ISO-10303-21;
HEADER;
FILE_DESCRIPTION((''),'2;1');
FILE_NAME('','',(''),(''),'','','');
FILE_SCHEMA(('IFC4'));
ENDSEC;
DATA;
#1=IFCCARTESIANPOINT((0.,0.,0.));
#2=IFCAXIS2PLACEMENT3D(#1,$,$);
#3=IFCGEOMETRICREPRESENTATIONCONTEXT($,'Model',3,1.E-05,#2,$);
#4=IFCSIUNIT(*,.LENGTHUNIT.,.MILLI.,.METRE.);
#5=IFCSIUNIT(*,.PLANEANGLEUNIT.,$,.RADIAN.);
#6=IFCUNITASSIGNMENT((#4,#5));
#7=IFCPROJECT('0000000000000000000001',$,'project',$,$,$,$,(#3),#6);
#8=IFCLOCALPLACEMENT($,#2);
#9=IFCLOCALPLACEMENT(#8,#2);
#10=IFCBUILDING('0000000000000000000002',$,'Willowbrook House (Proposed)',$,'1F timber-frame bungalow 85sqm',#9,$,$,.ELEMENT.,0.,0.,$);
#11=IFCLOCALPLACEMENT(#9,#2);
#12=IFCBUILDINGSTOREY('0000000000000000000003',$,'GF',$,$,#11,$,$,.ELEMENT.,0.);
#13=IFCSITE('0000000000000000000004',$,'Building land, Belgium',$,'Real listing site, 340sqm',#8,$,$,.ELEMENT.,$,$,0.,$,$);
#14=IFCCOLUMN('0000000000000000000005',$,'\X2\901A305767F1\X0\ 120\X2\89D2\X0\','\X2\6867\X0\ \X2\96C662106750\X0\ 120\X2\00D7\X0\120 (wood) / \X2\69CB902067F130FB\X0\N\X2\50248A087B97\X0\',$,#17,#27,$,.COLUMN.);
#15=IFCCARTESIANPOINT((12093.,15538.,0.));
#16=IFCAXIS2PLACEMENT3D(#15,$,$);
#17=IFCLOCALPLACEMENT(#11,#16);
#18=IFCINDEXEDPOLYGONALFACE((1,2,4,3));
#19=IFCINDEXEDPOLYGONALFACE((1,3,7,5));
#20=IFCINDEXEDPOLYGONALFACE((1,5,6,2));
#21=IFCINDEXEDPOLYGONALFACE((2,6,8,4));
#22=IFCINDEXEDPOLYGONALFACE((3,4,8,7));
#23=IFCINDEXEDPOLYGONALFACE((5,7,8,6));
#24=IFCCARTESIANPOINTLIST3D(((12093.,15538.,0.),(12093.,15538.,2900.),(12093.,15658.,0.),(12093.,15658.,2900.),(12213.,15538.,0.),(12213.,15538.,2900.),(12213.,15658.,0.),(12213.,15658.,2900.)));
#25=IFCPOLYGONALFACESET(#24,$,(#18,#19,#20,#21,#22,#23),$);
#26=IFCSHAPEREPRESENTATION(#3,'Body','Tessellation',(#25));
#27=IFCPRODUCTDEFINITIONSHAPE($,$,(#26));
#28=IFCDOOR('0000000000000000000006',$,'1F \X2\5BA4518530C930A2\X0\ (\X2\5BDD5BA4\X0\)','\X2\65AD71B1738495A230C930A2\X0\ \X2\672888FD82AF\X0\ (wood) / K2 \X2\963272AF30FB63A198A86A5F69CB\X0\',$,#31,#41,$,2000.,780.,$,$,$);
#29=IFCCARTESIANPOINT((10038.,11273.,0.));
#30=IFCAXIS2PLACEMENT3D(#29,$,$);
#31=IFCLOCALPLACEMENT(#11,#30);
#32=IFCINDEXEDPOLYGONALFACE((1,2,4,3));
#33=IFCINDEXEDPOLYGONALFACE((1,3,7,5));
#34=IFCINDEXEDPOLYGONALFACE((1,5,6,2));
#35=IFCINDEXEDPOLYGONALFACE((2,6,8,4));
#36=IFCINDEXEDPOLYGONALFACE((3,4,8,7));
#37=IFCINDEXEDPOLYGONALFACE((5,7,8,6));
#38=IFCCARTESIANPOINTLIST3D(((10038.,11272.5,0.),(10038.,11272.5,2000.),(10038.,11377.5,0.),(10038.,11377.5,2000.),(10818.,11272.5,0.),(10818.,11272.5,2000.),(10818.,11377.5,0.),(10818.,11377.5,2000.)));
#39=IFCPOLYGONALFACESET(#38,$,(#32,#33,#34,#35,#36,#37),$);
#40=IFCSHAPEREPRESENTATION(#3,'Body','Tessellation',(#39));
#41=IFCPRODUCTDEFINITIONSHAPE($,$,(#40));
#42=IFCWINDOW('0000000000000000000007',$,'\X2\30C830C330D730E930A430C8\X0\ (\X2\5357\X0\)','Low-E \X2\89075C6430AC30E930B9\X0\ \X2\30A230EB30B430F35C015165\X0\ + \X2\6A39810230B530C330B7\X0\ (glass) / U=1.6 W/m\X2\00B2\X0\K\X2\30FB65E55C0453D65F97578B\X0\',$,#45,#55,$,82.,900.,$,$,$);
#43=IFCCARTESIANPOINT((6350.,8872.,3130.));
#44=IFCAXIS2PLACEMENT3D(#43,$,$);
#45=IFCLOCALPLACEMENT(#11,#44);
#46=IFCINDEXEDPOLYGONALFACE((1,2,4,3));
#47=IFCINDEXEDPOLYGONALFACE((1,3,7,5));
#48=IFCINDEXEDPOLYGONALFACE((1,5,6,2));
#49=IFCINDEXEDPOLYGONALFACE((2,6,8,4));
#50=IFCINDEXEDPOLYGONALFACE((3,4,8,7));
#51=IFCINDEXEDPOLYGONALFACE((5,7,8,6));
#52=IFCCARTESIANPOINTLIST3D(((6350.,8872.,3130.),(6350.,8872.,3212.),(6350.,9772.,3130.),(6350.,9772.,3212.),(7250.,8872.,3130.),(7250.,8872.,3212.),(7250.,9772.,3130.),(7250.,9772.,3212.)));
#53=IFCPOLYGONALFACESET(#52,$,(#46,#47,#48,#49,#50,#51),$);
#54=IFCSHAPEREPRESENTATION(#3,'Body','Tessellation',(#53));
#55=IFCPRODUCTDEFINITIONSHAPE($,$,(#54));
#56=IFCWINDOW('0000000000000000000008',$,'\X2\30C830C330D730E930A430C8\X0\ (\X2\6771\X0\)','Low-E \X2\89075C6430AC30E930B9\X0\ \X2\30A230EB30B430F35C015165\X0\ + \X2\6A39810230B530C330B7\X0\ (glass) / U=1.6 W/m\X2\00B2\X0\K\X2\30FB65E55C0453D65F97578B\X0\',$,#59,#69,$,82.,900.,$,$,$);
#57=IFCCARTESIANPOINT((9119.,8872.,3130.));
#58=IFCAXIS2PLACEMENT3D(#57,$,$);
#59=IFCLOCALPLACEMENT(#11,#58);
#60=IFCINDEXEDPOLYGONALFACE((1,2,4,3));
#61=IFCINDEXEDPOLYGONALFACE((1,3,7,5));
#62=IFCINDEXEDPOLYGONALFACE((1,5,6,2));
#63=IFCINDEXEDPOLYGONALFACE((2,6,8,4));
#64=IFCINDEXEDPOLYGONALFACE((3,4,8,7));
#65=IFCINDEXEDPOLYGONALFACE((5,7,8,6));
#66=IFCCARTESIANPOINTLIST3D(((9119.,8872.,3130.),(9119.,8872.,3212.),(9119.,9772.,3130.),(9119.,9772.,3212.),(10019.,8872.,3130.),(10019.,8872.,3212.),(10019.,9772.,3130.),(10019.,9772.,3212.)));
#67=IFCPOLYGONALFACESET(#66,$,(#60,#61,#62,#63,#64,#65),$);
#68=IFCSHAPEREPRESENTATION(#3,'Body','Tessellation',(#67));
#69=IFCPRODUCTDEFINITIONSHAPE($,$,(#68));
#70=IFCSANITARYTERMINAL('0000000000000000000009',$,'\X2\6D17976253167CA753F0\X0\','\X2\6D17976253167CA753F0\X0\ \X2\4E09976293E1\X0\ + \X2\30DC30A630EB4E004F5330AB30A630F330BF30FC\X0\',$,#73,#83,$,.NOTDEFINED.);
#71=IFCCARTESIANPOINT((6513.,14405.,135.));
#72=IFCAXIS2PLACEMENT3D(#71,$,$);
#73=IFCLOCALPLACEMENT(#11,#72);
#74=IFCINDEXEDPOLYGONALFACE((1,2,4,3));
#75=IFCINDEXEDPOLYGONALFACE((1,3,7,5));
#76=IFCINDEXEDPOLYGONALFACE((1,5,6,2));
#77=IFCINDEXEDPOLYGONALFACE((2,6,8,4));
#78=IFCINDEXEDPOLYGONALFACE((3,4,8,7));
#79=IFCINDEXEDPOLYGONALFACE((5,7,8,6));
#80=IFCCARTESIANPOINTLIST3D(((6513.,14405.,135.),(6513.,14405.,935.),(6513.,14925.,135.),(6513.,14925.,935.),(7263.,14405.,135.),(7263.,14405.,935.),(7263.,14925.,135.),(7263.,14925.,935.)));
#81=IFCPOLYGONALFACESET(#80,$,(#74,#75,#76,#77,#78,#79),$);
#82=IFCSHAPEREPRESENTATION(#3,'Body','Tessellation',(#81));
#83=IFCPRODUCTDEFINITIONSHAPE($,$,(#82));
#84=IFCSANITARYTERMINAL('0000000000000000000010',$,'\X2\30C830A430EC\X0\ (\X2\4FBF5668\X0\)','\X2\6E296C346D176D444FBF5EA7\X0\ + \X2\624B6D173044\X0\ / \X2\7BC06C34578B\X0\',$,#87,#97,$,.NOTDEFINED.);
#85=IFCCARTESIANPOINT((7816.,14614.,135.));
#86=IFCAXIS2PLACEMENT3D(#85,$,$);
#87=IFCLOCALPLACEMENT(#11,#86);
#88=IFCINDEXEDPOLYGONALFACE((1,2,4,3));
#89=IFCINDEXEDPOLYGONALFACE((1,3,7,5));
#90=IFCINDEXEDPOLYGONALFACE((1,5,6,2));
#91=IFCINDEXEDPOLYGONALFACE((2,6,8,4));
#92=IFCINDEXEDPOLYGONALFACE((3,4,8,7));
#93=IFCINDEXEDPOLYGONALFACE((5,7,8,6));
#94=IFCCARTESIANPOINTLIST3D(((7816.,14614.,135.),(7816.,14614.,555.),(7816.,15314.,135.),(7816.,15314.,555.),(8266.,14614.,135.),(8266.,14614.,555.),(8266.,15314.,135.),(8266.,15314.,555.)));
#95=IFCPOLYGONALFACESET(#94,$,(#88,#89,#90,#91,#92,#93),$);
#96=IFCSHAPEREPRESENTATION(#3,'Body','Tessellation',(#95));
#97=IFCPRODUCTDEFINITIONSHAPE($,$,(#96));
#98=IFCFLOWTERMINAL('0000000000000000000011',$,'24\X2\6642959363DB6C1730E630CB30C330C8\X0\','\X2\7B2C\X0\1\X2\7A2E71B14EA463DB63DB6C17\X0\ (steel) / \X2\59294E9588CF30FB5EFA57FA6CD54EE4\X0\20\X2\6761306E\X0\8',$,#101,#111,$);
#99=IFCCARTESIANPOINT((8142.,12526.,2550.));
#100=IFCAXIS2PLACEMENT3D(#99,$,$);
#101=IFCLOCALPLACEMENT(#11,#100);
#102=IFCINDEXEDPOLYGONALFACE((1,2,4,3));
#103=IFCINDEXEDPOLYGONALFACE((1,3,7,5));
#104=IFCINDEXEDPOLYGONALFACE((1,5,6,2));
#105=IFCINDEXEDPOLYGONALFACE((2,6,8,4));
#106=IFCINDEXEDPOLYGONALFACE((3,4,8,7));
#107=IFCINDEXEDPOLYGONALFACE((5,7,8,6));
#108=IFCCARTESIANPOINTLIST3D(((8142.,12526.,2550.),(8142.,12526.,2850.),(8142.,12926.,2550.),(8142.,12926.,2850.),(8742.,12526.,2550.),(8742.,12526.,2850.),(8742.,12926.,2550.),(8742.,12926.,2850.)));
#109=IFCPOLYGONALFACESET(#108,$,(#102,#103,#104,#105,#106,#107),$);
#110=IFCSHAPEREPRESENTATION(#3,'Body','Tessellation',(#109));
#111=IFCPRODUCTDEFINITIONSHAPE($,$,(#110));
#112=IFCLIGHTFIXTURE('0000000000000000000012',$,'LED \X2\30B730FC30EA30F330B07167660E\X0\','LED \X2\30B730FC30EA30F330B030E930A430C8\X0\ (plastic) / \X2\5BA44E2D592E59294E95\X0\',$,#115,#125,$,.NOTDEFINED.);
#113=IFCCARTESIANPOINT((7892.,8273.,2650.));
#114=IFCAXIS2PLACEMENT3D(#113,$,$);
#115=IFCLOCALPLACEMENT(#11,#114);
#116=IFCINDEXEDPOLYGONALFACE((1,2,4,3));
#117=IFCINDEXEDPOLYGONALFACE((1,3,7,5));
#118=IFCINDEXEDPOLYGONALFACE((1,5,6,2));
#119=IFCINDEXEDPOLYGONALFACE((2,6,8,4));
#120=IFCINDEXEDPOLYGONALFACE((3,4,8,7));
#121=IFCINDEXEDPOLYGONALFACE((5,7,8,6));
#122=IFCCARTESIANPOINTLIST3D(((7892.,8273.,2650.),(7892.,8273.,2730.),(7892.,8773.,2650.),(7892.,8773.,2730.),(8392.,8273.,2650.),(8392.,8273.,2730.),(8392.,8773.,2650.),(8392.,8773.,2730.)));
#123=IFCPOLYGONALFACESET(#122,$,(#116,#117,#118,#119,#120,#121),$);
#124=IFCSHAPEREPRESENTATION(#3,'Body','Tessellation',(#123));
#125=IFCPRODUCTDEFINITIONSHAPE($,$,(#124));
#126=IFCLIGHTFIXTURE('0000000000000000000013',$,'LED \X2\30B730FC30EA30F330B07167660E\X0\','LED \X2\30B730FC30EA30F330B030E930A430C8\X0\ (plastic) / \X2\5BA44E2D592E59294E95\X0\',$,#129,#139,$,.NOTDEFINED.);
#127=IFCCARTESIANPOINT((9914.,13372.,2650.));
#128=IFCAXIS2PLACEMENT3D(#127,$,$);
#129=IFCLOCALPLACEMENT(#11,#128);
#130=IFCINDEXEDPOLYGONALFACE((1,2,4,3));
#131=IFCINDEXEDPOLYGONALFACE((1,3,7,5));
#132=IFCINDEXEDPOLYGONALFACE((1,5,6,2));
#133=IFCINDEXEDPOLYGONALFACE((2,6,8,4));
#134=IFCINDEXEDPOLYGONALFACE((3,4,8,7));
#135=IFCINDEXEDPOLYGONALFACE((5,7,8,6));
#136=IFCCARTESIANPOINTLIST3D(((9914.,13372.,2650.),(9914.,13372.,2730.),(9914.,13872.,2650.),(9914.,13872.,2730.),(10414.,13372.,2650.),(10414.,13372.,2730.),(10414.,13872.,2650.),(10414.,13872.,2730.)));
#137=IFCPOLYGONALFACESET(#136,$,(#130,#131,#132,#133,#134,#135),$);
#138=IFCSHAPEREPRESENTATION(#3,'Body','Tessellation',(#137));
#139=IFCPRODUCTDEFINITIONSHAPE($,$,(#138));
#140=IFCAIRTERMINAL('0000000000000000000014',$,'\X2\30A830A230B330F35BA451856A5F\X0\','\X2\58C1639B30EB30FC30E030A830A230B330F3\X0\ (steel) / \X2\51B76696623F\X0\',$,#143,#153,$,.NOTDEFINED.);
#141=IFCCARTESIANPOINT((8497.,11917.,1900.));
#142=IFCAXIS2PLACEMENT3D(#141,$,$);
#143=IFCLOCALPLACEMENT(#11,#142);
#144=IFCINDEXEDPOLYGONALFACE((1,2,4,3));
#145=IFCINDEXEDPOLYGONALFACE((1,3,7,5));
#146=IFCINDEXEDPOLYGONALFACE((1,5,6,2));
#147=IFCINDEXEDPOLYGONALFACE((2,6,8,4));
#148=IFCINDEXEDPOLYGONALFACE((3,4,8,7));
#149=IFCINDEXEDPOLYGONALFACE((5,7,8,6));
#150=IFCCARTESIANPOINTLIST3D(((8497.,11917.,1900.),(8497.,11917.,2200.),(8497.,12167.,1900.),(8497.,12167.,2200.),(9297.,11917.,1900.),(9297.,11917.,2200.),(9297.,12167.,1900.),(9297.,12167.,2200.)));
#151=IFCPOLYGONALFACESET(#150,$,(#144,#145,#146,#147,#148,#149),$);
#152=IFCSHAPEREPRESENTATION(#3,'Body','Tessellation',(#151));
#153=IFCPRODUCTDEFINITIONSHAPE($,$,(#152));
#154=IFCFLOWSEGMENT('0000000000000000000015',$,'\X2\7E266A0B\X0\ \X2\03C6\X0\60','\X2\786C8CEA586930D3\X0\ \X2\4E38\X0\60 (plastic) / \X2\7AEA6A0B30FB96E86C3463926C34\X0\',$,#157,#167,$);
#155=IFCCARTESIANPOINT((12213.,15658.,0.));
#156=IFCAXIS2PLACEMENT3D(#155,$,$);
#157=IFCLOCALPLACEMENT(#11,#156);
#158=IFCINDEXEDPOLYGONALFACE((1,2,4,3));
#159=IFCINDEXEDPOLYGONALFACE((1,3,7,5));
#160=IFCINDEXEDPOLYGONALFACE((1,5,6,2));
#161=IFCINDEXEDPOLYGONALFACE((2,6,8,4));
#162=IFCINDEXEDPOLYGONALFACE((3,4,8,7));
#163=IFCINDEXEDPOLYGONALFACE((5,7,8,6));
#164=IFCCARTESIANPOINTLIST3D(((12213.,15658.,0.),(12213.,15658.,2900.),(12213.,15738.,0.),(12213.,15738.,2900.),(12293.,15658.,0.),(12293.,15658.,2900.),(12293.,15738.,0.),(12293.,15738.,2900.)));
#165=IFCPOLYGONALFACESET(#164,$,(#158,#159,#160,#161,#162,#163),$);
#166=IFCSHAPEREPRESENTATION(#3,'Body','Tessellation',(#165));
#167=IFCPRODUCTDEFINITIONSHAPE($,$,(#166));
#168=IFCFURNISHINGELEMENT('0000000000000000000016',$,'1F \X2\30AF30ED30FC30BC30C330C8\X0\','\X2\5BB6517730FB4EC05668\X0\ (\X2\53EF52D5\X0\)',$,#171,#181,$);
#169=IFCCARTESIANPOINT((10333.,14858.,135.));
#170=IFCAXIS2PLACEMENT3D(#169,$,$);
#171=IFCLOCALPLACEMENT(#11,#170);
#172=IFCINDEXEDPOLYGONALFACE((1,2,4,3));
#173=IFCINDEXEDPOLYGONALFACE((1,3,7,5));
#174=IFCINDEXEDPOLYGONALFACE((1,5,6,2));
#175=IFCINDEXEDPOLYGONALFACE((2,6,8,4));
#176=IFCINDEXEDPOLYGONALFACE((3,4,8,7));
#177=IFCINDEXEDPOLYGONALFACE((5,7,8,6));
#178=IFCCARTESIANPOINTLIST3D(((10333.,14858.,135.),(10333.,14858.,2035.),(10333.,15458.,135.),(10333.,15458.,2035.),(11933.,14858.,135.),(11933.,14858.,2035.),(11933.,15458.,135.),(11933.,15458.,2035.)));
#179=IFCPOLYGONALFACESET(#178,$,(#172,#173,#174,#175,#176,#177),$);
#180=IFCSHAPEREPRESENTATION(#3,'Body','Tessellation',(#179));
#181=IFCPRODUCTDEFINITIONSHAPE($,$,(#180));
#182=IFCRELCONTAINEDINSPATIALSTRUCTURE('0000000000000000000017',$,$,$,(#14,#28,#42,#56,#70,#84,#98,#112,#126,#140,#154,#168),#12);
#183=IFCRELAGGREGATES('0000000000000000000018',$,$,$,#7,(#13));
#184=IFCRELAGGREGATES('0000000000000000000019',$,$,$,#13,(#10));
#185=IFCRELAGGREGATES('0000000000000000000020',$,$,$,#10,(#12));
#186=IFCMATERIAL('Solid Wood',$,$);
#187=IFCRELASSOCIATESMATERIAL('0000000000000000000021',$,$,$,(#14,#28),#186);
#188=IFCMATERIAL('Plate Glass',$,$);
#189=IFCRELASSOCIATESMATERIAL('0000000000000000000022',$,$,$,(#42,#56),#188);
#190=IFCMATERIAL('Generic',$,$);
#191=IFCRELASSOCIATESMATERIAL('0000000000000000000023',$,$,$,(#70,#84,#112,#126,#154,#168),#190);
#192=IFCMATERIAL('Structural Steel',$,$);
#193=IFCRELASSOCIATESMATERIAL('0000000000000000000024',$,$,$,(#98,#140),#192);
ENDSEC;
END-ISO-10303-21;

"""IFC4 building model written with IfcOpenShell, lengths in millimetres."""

from ifc_helpers import new_model, si_unit, frame, frame_2d, origin, place, context, project, spatial, rectangle, extrude, material, element, save


model = new_model("IFC4")

# Units and contexts
model_context = context("Model", 3, precision=1e-05, world=origin())
ifc_project = project(units=[si_unit("LENGTHUNIT", "METRE", prefix="MILLI"), si_unit("PLANEANGLEUNIT", "RADIAN")], contexts=[model_context])

# Site, building, storey
site_placement = place(None, origin())
site = spatial("IfcSite", under=ifc_project, at=site_placement, Name="Building land, Belgium", ObjectType="Real listing site, 340sqm", CompositionType="ELEMENT", RefElevation=0.0)
building_placement = place(site_placement, origin())
building = spatial("IfcBuilding", under=site, at=building_placement, Name="Willowbrook House (Proposed)", ObjectType="1F timber-frame bungalow 85sqm", CompositionType="ELEMENT", ElevationOfRefHeight=0.0, ElevationOfTerrain=0.0)
storey_placement = place(building_placement, origin())
storey = spatial("IfcBuildingStorey", under=building, at=storey_placement, Name="GF", CompositionType="ELEMENT", Elevation=0.0)

# Column
ifc_material_1 = material(Name="Solid Wood")
column_1_placement = place(storey_placement, frame((12093.0, 15538.0, 0.0)))
element("IfcColumn", 1, at=column_1_placement, inside=storey, material=ifc_material_1, Name="通し柱 120角", Description="桧 集成材 120×120 (wood) / 構造柱・N値計算", PredefinedType="COLUMN", context=model_context, shape_type="SweptSolid", body=[
    extrude(rectangle(XDim=120.0, YDim=120.0, at=frame_2d((60.0, 60.0))), frame((12093.0, 15538.0, 0.0)), (0.0, 0.0, 1.0), 2900.0),
])

# Door
door_placement = place(storey_placement, frame((10038.0, 11273.0, 0.0)))
element("IfcDoor", 2, at=door_placement, inside=storey, material=ifc_material_1, Name="1F 室内ドア (寝室)", Description="断熱玄関ドア 木製芯 (wood) / K2 防犯・採風機構", OverallHeight=2000.0, OverallWidth=780.0, context=model_context, shape_type="SweptSolid", body=[
    extrude(rectangle(XDim=780.0, YDim=105.0, at=frame_2d((390.0, 52.0))), frame((10038.0, 11273.0, 0.0)), (0.0, 0.0, 1.0), 2000.0),
])

# Windows
ifc_material_2 = material(Name="Plate Glass")
window_1_placement = place(storey_placement, frame((6350.0, 8872.0, 3130.0)))
element("IfcWindow", 3, at=window_1_placement, inside=storey, material=ifc_material_2, Name="トップライト (南)", Description="Low-E 複層ガラス アルゴン封入 + 樹脂サッシ (glass) / U=1.6 W/m²K・日射取得型", OverallHeight=82.0, OverallWidth=900.0, context=model_context, shape_type="SweptSolid", body=[
    extrude(rectangle(XDim=900.0, YDim=900.0, at=frame_2d((450.0, 450.0))), frame((6350.0, 8872.0, 3130.0)), (0.0, 0.0, 1.0), 82.0),
])
window_2_placement = place(storey_placement, frame((9119.0, 8872.0, 3130.0)))
element("IfcWindow", 4, at=window_2_placement, inside=storey, material=ifc_material_2, Name="トップライト (東)", Description="Low-E 複層ガラス アルゴン封入 + 樹脂サッシ (glass) / U=1.6 W/m²K・日射取得型", OverallHeight=82.0, OverallWidth=900.0, context=model_context, shape_type="SweptSolid", body=[
    extrude(rectangle(XDim=900.0, YDim=900.0, at=frame_2d((450.0, 450.0))), frame((9119.0, 8872.0, 3130.0)), (0.0, 0.0, 1.0), 82.0),
])

# Sanitary terminals
ifc_material_3 = material(Name="Generic")
sanitary_terminal_1_placement = place(storey_placement, frame((6513.0, 14405.0, 135.0)))
element("IfcSanitaryTerminal", 5, at=sanitary_terminal_1_placement, inside=storey, material=ifc_material_3, Name="洗面化粧台", Description="洗面化粧台 三面鏡 + ボウル一体カウンター", PredefinedType="NOTDEFINED", context=model_context, shape_type="SweptSolid", body=[
    extrude(rectangle(XDim=750.0, YDim=520.0, at=frame_2d((375.0, 260.0))), frame((6513.0, 14405.0, 135.0)), (0.0, 0.0, 1.0), 800.0),
])
sanitary_terminal_2_placement = place(storey_placement, frame((7816.0, 14614.0, 135.0)))
element("IfcSanitaryTerminal", 6, at=sanitary_terminal_2_placement, inside=storey, material=ifc_material_3, Name="トイレ (便器)", Description="温水洗浄便座 + 手洗い / 節水型", PredefinedType="NOTDEFINED", context=model_context, shape_type="SweptSolid", body=[
    extrude(rectangle(XDim=450.0, YDim=700.0, at=frame_2d((225.0, 350.0))), frame((7816.0, 14614.0, 135.0)), (0.0, 0.0, 1.0), 420.0),
])

# Flow terminal
ifc_material_4 = material(Name="Structural Steel")
flow_terminal_placement = place(storey_placement, frame((8142.0, 12526.0, 2550.0)))
element("IfcFlowTerminal", 7, at=flow_terminal_placement, inside=storey, material=ifc_material_4, Name="24時間換気ユニット", Description="第1種熱交換換気 (steel) / 天井裏・建基法令20条の8", context=model_context, shape_type="SweptSolid", body=[
    extrude(rectangle(XDim=600.0, YDim=400.0, at=frame_2d((300.0, 200.0))), frame((8142.0, 12526.0, 2550.0)), (0.0, 0.0, 1.0), 300.0),
])

# Light fixtures
light_fixture_1_placement = place(storey_placement, frame((7892.0, 8273.0, 2650.0)))
element("IfcLightFixture", 8, at=light_fixture_1_placement, inside=storey, material=ifc_material_3, Name="LED シーリング照明", Description="LED シーリングライト (plastic) / 室中央天井", PredefinedType="NOTDEFINED", context=model_context, shape_type="SweptSolid", body=[
    extrude(rectangle(XDim=500.0, YDim=500.0, at=frame_2d((250.0, 250.0))), frame((7892.0, 8273.0, 2650.0)), (0.0, 0.0, 1.0), 80.0),
])
light_fixture_2_placement = place(storey_placement, frame((9914.0, 13372.0, 2650.0)))
element("IfcLightFixture", 9, at=light_fixture_2_placement, inside=storey, material=ifc_material_3, Name="LED シーリング照明", Description="LED シーリングライト (plastic) / 室中央天井", PredefinedType="NOTDEFINED", context=model_context, shape_type="SweptSolid", body=[
    extrude(rectangle(XDim=500.0, YDim=500.0, at=frame_2d((250.0, 250.0))), frame((9914.0, 13372.0, 2650.0)), (0.0, 0.0, 1.0), 80.0),
])

# Air terminal
air_terminal_placement = place(storey_placement, frame((8497.0, 11917.0, 1900.0)))
element("IfcAirTerminal", 10, at=air_terminal_placement, inside=storey, material=ifc_material_4, Name="エアコン室内機", Description="壁掛ルームエアコン (steel) / 冷暖房", PredefinedType="NOTDEFINED", context=model_context, shape_type="SweptSolid", body=[
    extrude(rectangle(XDim=800.0, YDim=250.0, at=frame_2d((400.0, 125.0))), frame((8497.0, 11917.0, 1900.0)), (0.0, 0.0, 1.0), 300.0),
])

# Flow segment
flow_segment_placement = place(storey_placement, frame((12213.0, 15658.0, 0.0)))
element("IfcFlowSegment", 11, at=flow_segment_placement, inside=storey, material=ifc_material_3, Name="縦樋 φ60", Description="硬質塩ビ 丸60 (plastic) / 竪樋・雨水排水", context=model_context, shape_type="SweptSolid", body=[
    extrude(rectangle(XDim=80.0, YDim=80.0, at=frame_2d((40.0, 40.0))), frame((12213.0, 15658.0, 0.0)), (0.0, 0.0, 1.0), 2900.0),
])

# Furnishing element
furnishing_placement = place(storey_placement, frame((10333.0, 14858.0, 135.0)))
element("IfcFurnishingElement", 12, at=furnishing_placement, inside=storey, material=ifc_material_3, Name="1F クローゼット", Description="家具・什器 (可動)", context=model_context, shape_type="SweptSolid", body=[
    extrude(rectangle(XDim=1600.0, YDim=600.0, at=frame_2d((800.0, 300.0))), frame((10333.0, 14858.0, 135.0)), (0.0, 0.0, 1.0), 1900.0),
])

save(model, "model.ifc")
